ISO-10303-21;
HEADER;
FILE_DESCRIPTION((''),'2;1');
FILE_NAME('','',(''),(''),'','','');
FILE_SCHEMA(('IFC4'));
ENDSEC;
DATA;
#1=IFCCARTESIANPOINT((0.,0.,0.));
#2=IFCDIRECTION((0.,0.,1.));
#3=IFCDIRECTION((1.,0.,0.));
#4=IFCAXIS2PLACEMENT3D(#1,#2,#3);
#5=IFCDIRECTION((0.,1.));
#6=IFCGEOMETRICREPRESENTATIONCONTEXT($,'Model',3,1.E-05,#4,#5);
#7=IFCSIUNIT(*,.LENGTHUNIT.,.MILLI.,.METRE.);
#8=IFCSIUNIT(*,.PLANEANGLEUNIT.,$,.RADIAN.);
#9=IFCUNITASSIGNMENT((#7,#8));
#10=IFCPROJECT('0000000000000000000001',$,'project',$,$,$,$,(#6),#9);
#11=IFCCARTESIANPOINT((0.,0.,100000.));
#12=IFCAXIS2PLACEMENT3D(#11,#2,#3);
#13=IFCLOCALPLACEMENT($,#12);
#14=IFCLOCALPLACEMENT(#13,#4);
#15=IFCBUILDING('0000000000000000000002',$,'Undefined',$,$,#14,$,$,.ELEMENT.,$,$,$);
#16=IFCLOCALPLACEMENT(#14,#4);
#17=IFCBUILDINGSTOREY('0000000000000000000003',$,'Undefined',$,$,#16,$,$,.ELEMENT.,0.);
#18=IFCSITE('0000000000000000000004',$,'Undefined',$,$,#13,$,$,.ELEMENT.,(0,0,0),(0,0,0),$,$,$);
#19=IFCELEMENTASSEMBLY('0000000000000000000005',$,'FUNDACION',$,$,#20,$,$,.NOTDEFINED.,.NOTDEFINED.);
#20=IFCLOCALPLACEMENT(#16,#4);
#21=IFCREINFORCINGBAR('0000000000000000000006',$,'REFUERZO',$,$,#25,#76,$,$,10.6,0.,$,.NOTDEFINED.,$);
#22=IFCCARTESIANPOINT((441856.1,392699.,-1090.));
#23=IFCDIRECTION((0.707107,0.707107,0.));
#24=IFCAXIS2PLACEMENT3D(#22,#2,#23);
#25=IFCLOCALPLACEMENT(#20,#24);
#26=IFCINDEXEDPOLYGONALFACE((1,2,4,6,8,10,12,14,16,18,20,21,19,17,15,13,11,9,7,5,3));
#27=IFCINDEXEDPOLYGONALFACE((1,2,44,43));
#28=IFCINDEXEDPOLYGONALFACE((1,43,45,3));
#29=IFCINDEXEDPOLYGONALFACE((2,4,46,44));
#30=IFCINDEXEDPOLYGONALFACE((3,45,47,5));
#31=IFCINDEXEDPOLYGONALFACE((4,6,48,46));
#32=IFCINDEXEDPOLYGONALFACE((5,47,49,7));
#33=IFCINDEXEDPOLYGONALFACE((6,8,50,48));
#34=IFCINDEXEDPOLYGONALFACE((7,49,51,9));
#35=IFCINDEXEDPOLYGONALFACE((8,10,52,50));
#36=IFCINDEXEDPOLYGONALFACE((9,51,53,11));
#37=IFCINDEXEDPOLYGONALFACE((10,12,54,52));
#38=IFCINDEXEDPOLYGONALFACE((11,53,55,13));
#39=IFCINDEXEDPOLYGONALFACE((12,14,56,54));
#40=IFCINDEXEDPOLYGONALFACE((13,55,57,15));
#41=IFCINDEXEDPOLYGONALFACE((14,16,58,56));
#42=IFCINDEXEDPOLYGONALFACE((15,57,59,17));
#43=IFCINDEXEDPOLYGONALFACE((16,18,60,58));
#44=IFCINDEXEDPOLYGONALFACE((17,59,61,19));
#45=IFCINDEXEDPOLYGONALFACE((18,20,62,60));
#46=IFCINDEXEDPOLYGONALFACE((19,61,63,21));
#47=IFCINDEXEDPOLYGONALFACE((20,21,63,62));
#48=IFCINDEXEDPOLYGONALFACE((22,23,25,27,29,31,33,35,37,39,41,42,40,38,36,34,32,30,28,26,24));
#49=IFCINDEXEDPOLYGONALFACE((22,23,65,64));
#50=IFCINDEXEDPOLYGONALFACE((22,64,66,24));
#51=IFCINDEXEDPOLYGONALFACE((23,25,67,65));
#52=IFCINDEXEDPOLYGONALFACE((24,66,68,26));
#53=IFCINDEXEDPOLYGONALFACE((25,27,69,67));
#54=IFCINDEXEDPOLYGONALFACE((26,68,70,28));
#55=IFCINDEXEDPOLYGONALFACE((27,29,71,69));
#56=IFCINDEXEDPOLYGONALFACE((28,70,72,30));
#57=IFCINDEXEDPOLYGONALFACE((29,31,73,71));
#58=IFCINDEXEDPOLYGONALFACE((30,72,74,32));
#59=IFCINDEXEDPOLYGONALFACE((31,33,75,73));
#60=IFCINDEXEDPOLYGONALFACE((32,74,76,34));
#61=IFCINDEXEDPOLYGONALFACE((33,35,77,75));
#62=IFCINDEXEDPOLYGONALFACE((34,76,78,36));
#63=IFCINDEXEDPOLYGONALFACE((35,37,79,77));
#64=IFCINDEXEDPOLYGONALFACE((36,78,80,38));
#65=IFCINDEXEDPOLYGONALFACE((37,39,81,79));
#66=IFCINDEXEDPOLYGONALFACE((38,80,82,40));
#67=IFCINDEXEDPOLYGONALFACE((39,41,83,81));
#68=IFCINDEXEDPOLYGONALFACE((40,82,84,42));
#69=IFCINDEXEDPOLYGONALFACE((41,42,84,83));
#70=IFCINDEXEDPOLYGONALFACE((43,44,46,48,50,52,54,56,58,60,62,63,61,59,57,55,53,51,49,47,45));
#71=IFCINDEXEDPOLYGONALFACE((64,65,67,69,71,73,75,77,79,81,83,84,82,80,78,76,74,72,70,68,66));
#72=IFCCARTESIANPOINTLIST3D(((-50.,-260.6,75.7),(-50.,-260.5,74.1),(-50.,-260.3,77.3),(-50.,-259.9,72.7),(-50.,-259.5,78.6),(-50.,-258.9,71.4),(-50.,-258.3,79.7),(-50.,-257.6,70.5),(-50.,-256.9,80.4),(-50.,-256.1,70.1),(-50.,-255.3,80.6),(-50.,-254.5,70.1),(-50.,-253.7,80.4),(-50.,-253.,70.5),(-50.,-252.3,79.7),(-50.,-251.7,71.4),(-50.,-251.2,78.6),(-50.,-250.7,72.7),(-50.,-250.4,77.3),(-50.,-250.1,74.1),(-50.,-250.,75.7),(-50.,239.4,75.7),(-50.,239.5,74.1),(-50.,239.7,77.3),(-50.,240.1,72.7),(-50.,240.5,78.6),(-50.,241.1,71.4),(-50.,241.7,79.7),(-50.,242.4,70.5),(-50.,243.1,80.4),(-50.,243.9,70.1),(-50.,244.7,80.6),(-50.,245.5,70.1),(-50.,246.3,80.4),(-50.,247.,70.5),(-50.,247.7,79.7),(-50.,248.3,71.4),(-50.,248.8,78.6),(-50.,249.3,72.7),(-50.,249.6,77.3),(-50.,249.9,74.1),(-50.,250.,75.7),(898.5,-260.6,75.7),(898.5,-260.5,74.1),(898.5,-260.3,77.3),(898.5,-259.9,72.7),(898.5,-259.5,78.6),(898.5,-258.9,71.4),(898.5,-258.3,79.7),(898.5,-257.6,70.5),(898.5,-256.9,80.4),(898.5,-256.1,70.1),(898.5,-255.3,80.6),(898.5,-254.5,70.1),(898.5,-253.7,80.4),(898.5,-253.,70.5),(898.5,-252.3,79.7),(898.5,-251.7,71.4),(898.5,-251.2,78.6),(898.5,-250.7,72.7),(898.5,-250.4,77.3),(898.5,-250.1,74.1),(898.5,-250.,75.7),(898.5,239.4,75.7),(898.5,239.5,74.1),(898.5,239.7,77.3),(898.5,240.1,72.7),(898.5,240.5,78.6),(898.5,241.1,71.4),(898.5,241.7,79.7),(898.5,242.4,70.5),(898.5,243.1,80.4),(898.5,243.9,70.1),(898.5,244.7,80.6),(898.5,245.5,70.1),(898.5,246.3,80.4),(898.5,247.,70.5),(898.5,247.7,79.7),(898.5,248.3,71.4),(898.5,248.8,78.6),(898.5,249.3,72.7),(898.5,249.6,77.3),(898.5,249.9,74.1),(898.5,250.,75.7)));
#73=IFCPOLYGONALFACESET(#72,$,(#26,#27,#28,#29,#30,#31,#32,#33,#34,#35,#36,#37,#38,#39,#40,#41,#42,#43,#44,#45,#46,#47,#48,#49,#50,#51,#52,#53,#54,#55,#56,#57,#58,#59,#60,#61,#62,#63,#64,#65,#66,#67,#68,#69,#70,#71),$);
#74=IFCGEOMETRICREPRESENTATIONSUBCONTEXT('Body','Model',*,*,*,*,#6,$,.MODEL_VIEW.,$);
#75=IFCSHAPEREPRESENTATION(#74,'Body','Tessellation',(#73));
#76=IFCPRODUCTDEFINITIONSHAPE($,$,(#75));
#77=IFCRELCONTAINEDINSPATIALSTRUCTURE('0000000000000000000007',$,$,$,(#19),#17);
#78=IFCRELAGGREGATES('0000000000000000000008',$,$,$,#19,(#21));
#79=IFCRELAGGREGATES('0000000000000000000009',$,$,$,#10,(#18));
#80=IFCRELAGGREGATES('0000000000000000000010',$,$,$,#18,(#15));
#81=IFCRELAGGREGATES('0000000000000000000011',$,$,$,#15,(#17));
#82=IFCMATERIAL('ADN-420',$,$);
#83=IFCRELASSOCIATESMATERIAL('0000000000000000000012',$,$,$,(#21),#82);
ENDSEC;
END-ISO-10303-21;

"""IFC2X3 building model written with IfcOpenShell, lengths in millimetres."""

from ifc_helpers import new_model, entity, si_unit, direction, frame, origin_with_axes, place, context, subcontext, project, spatial, source, transform, mapped, material, element, aggregate, save


model = new_model("IFC2X3")

# Units and contexts
model_context = context("Model", 3, precision=1e-05, world=origin_with_axes(), true_north=direction((0.0, 1.0)))
body_context = subcontext(model_context, "Body", "Model", "MODEL_VIEW")
ifc_project = project(units=[si_unit("LENGTHUNIT", "METRE", prefix="MILLI"), si_unit("PLANEANGLEUNIT", "RADIAN")], contexts=[model_context])

# Site, building, storey
site_placement = place(None, frame((0.0, 0.0, 100000.0), z_axis=(0.0, 0.0, 1.0), x_axis=(1.0, 0.0, 0.0)))
site = spatial("IfcSite", under=ifc_project, at=site_placement, Name="Undefined", CompositionType="ELEMENT", RefLatitude=(0, 0, 0), RefLongitude=(0, 0, 0))
building_placement = place(site_placement, origin_with_axes())
building = spatial("IfcBuilding", under=site, at=building_placement, Name="Undefined", CompositionType="ELEMENT")
storey_placement = place(building_placement, origin_with_axes())
storey = spatial("IfcBuildingStorey", under=building, at=storey_placement, Name="Undefined", CompositionType="ELEMENT", Elevation=0.0)

# Element assembly, reinforcing bar
assembly_1_placement = place(storey_placement, origin_with_axes())
assembly_1 = element("IfcElementAssembly", 1, at=assembly_1_placement, inside=storey, Name="FUNDACION", AssemblyPlace="NOTDEFINED", PredefinedType="NOTDEFINED")
ifc_material_1 = material(Name="ADN-420")
shared_shape_1 = source(origin_with_axes(), body_context, "Body", "AdvancedSweptSolid", [
    entity("IfcSweptDiskSolid", entity("IfcTrimmedCurve", entity("IfcLine", entity("IfcCartesianPoint", [0.0, 0.0, 0.0]), entity("IfcVector", entity("IfcDirection", [1.0, 0.0, 0.0]), 1.0)), [entity("IfcParameterValue", 0.0)], [entity("IfcParameterValue", 948.528137)], True, "PARAMETER"), 5.3, None, 0.0, 948.5),
])
shared_shape_2 = source(origin_with_axes(), body_context, "Body", "AdvancedSweptSolid", [
    entity("IfcSweptDiskSolid", entity("IfcTrimmedCurve", entity("IfcLine", entity("IfcCartesianPoint", [0.0, 0.0, 0.0]), entity("IfcVector", entity("IfcDirection", [1.0, 0.0, 0.0]), 1.0)), [entity("IfcParameterValue", 0.0)], [entity("IfcParameterValue", 948.528137)], True, "PARAMETER"), 5.3, None, 0.0, 948.5),
])
reinforcing_bar_placement = place(assembly_1_placement, frame((441856.1, 392699.0, -1090.0), z_axis=(0.0, 0.0, 1.0), x_axis=(0.707107, 0.707107, 0.0)))
reinforcing_bar = element("IfcReinforcingBar", 2, at=reinforcing_bar_placement, material=ifc_material_1, Name="REFUERZO", BarRole="NOTDEFINED", CrossSectionArea=0.0, NominalDiameter=10.6, context=body_context, shape_type="MappedRepresentation", body=[
    mapped(shared_shape_1, transform((-50.0, -255.3, 75.3))),
    mapped(shared_shape_2, transform((-50.0, 244.7, 75.3))),
])
aggregate(assembly_1, [reinforcing_bar])

save(model, "model.ifc")
